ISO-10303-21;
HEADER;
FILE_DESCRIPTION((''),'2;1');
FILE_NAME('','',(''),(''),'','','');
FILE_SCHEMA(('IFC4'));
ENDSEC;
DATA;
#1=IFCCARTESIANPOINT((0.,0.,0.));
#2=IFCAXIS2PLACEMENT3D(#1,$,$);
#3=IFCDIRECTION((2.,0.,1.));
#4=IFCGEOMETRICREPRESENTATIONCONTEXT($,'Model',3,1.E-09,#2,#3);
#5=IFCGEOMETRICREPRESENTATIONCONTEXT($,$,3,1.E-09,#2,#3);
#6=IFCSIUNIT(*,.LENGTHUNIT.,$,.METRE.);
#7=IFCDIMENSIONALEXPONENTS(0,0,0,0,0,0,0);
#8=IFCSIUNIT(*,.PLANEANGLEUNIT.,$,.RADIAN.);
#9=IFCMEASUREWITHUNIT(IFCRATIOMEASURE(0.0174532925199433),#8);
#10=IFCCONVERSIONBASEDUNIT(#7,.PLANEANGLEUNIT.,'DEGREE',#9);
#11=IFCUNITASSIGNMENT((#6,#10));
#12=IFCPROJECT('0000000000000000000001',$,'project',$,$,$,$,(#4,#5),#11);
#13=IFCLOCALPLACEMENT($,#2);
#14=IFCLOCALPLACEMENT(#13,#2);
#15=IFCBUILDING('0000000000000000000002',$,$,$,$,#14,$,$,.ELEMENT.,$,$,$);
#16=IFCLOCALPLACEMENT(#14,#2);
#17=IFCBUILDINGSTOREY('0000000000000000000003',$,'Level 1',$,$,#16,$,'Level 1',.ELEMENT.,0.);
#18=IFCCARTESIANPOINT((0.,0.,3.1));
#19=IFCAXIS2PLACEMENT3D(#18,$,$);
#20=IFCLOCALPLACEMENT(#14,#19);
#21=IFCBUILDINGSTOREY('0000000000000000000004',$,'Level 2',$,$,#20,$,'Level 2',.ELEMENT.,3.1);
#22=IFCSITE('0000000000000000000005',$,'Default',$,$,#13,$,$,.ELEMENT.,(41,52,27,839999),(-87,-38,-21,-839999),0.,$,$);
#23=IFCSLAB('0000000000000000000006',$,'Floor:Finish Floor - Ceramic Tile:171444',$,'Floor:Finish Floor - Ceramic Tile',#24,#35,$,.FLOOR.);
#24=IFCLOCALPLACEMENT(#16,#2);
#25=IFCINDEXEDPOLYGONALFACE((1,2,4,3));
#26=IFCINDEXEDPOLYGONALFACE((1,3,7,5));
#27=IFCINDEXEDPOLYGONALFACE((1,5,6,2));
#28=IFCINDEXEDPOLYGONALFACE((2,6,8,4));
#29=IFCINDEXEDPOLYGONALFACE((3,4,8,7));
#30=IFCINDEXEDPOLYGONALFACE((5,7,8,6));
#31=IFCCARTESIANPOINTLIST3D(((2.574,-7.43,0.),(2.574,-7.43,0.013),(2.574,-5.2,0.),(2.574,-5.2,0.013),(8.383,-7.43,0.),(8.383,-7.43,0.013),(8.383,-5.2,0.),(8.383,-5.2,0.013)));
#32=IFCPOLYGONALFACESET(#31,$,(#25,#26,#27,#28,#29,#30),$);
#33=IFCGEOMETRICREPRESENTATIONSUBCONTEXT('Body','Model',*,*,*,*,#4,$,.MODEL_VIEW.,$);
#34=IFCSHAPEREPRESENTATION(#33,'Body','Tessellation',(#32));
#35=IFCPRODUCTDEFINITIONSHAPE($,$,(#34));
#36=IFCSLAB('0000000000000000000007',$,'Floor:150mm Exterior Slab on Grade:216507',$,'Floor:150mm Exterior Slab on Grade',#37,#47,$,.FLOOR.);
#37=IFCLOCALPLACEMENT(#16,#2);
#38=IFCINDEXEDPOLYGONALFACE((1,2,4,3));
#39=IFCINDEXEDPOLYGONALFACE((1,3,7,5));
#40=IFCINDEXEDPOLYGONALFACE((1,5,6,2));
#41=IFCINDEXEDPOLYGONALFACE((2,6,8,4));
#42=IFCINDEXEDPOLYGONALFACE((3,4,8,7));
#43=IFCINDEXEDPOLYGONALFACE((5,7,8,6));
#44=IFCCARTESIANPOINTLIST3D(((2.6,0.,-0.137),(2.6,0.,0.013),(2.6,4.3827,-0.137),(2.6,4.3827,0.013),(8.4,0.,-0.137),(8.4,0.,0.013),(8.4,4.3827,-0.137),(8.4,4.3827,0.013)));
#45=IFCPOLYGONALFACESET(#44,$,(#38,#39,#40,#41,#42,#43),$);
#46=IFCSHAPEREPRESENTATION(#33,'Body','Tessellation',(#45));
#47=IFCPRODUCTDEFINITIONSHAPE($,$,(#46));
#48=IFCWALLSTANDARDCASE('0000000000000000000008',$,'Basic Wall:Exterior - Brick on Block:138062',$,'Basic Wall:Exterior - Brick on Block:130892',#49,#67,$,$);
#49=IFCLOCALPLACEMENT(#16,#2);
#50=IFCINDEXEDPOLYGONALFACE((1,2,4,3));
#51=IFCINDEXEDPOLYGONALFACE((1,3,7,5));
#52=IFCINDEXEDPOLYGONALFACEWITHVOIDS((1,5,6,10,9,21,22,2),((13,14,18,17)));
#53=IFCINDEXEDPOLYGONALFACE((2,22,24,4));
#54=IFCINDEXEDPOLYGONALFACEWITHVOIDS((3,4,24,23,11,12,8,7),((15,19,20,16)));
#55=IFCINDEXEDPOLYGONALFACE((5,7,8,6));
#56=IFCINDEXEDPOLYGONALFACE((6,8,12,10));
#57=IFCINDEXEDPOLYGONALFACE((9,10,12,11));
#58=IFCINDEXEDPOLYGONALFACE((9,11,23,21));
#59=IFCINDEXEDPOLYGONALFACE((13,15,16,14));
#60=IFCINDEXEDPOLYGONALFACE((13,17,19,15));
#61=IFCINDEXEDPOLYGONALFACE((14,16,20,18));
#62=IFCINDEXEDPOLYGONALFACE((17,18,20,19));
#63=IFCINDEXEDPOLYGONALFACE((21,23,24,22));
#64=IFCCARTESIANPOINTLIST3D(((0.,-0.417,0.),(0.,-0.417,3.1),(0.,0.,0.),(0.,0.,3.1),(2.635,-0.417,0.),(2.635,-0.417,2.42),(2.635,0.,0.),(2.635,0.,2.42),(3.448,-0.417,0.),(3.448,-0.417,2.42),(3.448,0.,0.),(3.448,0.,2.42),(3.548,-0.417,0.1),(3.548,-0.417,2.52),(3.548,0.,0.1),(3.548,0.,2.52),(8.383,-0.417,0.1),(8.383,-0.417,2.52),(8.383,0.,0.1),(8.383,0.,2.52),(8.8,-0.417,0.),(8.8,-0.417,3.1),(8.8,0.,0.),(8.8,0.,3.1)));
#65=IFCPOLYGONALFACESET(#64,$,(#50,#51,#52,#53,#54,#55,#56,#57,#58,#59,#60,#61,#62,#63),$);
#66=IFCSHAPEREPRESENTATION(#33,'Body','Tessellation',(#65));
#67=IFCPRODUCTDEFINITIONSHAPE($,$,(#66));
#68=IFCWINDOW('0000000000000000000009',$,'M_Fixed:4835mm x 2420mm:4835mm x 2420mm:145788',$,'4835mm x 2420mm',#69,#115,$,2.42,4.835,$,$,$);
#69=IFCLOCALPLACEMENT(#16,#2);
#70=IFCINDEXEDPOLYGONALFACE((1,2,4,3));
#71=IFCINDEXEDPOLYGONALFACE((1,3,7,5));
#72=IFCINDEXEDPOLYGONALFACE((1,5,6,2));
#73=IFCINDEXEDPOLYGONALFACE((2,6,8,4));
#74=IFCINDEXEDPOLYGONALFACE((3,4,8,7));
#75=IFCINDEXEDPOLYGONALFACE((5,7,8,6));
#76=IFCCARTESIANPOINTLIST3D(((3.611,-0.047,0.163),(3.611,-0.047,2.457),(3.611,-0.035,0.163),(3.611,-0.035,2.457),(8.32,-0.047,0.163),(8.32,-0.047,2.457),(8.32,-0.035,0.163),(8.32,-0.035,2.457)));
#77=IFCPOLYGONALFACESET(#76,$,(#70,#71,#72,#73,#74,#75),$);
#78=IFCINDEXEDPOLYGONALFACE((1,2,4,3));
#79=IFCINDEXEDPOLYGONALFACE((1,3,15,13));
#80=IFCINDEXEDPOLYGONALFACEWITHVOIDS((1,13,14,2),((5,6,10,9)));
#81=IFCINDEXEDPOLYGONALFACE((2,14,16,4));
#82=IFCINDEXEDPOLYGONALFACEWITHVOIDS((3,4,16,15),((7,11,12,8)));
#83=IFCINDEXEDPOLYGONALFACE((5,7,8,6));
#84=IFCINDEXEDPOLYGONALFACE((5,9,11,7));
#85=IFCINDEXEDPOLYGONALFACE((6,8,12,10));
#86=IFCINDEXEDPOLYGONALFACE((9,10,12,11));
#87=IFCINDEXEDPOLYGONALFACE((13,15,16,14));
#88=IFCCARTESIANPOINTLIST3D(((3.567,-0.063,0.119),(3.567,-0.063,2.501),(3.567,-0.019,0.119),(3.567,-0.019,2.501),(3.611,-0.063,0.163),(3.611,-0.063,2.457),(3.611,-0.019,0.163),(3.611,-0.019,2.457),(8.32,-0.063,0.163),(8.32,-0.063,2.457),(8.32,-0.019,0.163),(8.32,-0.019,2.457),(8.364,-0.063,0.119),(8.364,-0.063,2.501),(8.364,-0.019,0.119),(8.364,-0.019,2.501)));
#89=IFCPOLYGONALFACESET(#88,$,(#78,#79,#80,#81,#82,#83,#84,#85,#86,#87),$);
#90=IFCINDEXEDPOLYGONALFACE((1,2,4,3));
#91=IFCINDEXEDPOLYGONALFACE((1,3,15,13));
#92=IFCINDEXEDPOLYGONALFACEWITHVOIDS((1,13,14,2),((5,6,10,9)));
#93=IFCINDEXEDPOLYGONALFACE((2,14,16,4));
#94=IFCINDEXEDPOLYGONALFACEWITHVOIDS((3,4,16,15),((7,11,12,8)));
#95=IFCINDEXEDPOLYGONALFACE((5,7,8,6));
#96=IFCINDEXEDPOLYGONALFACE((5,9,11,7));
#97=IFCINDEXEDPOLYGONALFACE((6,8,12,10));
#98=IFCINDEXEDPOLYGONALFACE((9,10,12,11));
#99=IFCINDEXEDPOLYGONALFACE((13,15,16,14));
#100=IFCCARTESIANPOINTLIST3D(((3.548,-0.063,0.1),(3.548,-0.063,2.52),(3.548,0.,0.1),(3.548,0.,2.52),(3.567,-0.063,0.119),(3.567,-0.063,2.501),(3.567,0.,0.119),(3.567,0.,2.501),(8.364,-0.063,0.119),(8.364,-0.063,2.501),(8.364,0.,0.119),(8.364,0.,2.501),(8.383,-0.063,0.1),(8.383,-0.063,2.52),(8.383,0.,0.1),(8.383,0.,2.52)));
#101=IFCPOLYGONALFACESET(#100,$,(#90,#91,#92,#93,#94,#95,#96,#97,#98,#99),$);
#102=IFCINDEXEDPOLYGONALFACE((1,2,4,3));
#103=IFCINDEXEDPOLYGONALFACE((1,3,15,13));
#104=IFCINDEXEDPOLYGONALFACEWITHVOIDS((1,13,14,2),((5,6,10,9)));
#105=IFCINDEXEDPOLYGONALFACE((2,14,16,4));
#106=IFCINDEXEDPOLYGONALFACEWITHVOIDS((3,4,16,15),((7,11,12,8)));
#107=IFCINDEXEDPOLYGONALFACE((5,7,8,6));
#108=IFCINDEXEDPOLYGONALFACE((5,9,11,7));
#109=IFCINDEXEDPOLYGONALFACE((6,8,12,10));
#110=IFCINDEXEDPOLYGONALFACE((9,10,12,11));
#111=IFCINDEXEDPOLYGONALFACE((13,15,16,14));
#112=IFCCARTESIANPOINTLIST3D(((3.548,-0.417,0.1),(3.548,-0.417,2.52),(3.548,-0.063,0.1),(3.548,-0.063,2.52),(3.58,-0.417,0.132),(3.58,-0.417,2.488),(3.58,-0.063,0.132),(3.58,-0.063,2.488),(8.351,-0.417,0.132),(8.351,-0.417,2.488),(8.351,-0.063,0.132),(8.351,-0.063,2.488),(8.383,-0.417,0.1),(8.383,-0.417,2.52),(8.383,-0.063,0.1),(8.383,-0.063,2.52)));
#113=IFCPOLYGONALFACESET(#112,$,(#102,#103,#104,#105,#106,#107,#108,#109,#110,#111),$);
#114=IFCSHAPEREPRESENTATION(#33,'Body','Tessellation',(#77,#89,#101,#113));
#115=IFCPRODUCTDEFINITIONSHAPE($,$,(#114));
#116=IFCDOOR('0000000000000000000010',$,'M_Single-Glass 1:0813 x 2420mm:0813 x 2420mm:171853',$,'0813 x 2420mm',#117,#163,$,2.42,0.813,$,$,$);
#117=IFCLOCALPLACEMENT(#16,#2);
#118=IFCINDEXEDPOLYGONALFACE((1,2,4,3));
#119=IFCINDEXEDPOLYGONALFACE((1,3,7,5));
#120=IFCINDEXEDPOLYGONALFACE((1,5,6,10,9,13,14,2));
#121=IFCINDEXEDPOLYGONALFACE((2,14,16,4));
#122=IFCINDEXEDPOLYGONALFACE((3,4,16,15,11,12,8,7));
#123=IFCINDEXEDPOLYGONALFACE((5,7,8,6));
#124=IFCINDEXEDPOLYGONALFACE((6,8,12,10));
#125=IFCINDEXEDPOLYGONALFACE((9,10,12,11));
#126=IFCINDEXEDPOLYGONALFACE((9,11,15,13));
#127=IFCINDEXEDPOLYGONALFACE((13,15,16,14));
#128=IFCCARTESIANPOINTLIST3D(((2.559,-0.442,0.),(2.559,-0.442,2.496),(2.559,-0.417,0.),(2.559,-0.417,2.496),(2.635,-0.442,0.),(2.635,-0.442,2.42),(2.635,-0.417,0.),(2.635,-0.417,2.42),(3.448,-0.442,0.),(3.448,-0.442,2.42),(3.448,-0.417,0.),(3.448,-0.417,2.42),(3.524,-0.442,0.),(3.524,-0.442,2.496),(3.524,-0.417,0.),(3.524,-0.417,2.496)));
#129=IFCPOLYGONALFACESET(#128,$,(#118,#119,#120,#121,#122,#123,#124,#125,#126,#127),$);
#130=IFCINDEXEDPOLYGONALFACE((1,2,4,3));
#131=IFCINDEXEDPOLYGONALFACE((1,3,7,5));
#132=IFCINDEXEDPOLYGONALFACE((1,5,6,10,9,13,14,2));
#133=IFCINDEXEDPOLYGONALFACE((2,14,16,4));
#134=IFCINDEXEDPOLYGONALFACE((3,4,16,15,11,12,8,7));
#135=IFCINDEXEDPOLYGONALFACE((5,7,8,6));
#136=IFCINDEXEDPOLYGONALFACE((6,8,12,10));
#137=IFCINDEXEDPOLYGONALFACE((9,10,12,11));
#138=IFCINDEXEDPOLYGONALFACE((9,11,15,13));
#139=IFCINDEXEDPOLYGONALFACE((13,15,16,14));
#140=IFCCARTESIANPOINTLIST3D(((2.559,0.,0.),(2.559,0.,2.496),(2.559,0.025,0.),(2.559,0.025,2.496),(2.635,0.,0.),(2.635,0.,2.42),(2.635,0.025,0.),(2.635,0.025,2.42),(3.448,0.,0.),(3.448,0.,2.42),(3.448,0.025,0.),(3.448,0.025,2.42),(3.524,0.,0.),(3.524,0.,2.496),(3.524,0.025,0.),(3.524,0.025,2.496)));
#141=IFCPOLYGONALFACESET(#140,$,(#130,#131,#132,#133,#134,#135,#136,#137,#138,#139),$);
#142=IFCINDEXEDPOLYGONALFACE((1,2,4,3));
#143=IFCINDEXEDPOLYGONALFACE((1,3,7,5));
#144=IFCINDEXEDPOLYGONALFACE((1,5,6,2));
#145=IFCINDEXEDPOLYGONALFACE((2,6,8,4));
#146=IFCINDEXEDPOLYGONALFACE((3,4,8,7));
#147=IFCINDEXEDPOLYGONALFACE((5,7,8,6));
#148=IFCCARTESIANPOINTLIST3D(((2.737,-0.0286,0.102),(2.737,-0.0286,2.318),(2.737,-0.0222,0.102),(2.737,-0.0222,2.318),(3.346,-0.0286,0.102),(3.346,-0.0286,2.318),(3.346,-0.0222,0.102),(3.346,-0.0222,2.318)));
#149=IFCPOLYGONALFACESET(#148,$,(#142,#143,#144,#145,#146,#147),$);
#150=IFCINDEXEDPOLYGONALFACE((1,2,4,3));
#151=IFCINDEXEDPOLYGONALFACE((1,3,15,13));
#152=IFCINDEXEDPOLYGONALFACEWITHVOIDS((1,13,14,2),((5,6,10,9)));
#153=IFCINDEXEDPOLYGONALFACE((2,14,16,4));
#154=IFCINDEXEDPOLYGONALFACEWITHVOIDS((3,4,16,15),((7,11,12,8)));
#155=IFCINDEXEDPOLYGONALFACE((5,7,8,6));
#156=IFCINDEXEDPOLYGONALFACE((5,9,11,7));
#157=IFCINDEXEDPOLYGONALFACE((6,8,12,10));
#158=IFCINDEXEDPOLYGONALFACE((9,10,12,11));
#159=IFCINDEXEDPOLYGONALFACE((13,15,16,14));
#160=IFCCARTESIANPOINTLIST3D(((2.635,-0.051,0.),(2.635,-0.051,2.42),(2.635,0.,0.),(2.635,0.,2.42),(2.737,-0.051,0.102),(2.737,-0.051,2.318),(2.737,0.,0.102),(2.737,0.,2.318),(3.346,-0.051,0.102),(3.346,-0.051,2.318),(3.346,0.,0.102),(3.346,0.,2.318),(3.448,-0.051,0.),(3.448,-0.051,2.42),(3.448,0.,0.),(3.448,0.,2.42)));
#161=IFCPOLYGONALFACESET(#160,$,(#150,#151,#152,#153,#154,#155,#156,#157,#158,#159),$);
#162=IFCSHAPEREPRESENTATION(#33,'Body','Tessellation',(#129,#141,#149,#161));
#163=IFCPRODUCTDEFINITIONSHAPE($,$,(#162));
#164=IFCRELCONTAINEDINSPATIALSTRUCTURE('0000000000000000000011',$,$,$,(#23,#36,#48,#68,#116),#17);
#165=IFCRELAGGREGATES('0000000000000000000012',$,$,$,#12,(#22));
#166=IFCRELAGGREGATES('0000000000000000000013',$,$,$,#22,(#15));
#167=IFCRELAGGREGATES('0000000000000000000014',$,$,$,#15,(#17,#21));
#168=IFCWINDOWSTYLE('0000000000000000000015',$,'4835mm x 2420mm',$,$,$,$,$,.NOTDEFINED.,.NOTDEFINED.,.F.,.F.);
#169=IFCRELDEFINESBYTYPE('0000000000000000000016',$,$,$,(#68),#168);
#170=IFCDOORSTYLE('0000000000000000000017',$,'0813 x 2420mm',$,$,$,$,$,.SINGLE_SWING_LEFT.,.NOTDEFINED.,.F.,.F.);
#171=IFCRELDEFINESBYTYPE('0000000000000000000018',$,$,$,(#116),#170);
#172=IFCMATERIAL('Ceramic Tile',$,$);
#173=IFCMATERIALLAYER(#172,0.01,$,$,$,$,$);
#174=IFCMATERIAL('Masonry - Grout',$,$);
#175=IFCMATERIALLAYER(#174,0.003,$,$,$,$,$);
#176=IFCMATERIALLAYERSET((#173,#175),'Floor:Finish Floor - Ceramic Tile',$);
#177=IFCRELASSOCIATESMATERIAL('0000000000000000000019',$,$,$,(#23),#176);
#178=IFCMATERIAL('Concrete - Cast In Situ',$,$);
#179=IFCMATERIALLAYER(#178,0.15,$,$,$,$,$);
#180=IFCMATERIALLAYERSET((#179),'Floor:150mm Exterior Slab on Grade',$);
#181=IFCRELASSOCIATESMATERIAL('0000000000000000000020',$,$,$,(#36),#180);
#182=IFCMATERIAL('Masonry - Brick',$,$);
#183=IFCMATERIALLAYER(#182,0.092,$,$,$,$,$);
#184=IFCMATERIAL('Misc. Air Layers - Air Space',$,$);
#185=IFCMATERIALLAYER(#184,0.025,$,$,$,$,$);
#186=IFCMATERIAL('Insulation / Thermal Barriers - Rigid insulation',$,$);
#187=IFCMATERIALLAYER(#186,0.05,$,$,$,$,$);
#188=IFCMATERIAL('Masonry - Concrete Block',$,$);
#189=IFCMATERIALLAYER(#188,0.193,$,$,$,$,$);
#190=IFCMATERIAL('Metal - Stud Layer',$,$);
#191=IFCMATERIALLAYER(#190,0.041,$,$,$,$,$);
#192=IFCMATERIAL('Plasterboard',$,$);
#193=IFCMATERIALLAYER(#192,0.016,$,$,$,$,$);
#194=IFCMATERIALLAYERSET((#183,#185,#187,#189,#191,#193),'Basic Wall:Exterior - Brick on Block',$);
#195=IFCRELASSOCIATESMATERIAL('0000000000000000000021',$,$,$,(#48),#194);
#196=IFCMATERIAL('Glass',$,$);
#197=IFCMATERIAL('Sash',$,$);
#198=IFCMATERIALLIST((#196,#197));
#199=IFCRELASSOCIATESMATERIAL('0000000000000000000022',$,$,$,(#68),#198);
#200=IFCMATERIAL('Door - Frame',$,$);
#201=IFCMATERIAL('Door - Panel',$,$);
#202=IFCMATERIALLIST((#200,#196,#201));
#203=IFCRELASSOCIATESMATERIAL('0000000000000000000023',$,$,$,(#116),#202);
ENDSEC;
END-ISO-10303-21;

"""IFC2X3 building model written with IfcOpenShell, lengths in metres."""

from ifc_helpers import new_model, entity, si_unit, converted_unit, direction, frame, frame_2d, origin, origin_2d_with_axis, place, context, subcontext, project, spatial, polyline, rectangle, outline, extrude, source, transform, mapped, material, material_list, layer, layer_set, layer_usage, type_object, type_shapes, element, fill, save


model = new_model("IFC2X3")

# Units and contexts
model_context = context("Model", 3, precision=1e-09, world=origin(), true_north=direction((2.0, 0.0, 1.0)))
context_of_model = context(None, 3, precision=1e-09, world=origin(), true_north=direction((2.0, 0.0, 1.0)))
body_context = subcontext(model_context, "Body", "Model", "MODEL_VIEW")
ifc_project = project(units=[si_unit("LENGTHUNIT", "METRE"), converted_unit("PLANEANGLEUNIT", "DEGREE", entity("IfcRatioMeasure", 0.0174532925199433), si_unit("PLANEANGLEUNIT", "RADIAN"), dimensions=[0, 0, 0, 0, 0, 0, 0])], contexts=[model_context, context_of_model])

# Site, building, storey
site_placement = place(None, origin())
site = spatial("IfcSite", under=ifc_project, at=site_placement, Name="Default", CompositionType="ELEMENT", RefLatitude=(41, 52, 27, 839999), RefLongitude=(-87, -38, -21, -839999), RefElevation=0.0)
building_placement = place(site_placement, origin())
building = spatial("IfcBuilding", under=site, at=building_placement, CompositionType="ELEMENT")
storey_1_placement = place(building_placement, origin())
storey_1 = spatial("IfcBuildingStorey", under=building, at=storey_1_placement, Name="Level 1", LongName="Level 1", CompositionType="ELEMENT", Elevation=0.0)

# Slabs
ifc_material_1 = material(Name="Ceramic Tile")
ifc_layer_1 = layer(ifc_material_1, 0.01)
ifc_material_2 = material(Name="Masonry - Grout")
ifc_layer_2 = layer(ifc_material_2, 0.003)
ifc_layer_set_1 = layer_set([ifc_layer_1, ifc_layer_2], Name="Floor:Finish Floor - Ceramic Tile")
ifc_layer_usage_1 = layer_usage(ifc_layer_set_1, "AXIS3", "POSITIVE", 0.0)
slab_1_placement = place(storey_1_placement, frame((2.574, -7.43, 0.0)))
element("IfcSlab", 1, at=slab_1_placement, inside=storey_1, material=ifc_layer_usage_1, Name="Floor:Finish Floor - Ceramic Tile:171444", ObjectType="Floor:Finish Floor - Ceramic Tile", PredefinedType="FLOOR", context=body_context, shape_type="SweptSolid", body=[
    extrude(rectangle(XDim=5.809, YDim=2.23, at=frame_2d((0.0, 0.0), x_axis=(-1.0, 0.0))), frame((2.9045, 1.115, 0.013), z_axis=(0.0, 0.0, -1.0), x_axis=(-1.0, 0.0, 0.0)), (0.0, 0.0, 1.0), 0.013),
])
ifc_material_3 = material(Name="Concrete - Cast In Situ")
ifc_layer_3 = layer(ifc_material_3, 0.15)
ifc_layer_set_2 = layer_set([ifc_layer_3], Name="Floor:150mm Exterior Slab on Grade")
ifc_layer_usage_2 = layer_usage(ifc_layer_set_2, "AXIS3", "POSITIVE", 0.0)
slab_2_placement = place(storey_1_placement, frame((2.6, 0.0, -0.137)))
element("IfcSlab", 2, at=slab_2_placement, inside=storey_1, material=ifc_layer_usage_2, Name="Floor:150mm Exterior Slab on Grade:216507", ObjectType="Floor:150mm Exterior Slab on Grade", PredefinedType="FLOOR", context=body_context, shape_type="SweptSolid", body=[
    extrude(rectangle(XDim=5.8, YDim=4.3827, at=frame_2d((0.0, 0.0), x_axis=(-1.0, 0.0))), frame((2.9, 2.1914, 0.15), z_axis=(0.0, 0.0, -1.0), x_axis=(-1.0, 0.0, 0.0)), (0.0, 0.0, 1.0), 0.15),
])

# Wall, openings, window, door
ifc_material_4 = material(Name="Masonry - Brick")
ifc_layer_4 = layer(ifc_material_4, 0.092)
ifc_material_5 = material(Name="Misc. Air Layers - Air Space")
ifc_layer_5 = layer(ifc_material_5, 0.025)
ifc_material_6 = material(Name="Insulation / Thermal Barriers - Rigid insulation")
ifc_layer_6 = layer(ifc_material_6, 0.05)
ifc_material_7 = material(Name="Masonry - Concrete Block")
ifc_layer_7 = layer(ifc_material_7, 0.193)
ifc_material_8 = material(Name="Metal - Stud Layer")
ifc_layer_8 = layer(ifc_material_8, 0.041)
ifc_material_9 = material(Name="Plasterboard")
ifc_layer_9 = layer(ifc_material_9, 0.016)
ifc_layer_set_3 = layer_set([ifc_layer_4, ifc_layer_5, ifc_layer_6, ifc_layer_7, ifc_layer_8, ifc_layer_9], Name="Basic Wall:Exterior - Brick on Block")
ifc_layer_usage_3 = layer_usage(ifc_layer_set_3, "AXIS2", "NEGATIVE", 0.2085)
wall_1_placement = place(storey_1_placement, frame((0.0, -0.2085, 0.0)))
wall_1 = element("IfcWallStandardCase", 3, at=wall_1_placement, inside=storey_1, material=ifc_layer_usage_3, Name="Basic Wall:Exterior - Brick on Block:138062", ObjectType="Basic Wall:Exterior - Brick on Block:130892", context=body_context, shape_type="SweptSolid", body=[
    extrude(rectangle(XDim=8.8, YDim=0.417, at=frame_2d((4.4, 0.0), x_axis=(-1.0, 0.0))), origin(), (0.0, 0.0, 1.0), 3.1),
])
opening_1_placement = place(wall_1_placement, frame((3.548, -0.2085, 0.1)))
opening_1 = element("IfcOpeningElement", 4, at=opening_1_placement, cuts=wall_1, ObjectType="Opening", context=body_context, shape_type="SweptSolid", body=[
    extrude(rectangle(XDim=2.42, YDim=4.835, at=frame_2d((1.21, 2.4175), x_axis=(1.0, 0.0))), frame((0.0, 0.0, 0.0), z_axis=(0.0, 1.0, 0.0), x_axis=(0.0, 0.0, 1.0)), (0.0, 0.0, 1.0), 0.417),
])
opening_2_placement = place(wall_1_placement, frame((2.635, -0.2085, 0.0)))
opening_2 = element("IfcOpeningElement", 5, at=opening_2_placement, cuts=wall_1, ObjectType="Opening", context=body_context, shape_type="SweptSolid", body=[
    extrude(rectangle(XDim=0.813, YDim=2.42, at=frame_2d((1.21, 0.4065), x_axis=(0.0, -1.0))), frame((0.0, 0.0, 0.0), z_axis=(0.0, 1.0, 0.0), x_axis=(0.0, 0.0, 1.0)), (0.0, 0.0, 1.0), 0.417),
])
ifc_material_10 = material(Name="Glass")
ifc_material_11 = material(Name="Sash")
ifc_material_list_1 = material_list([ifc_material_10, ifc_material_11])
window_style = type_object("IfcWindowStyle", Name="4835mm x 2420mm", ConstructionType="NOTDEFINED", OperationType="NOTDEFINED", ParameterTakesPrecedence=False, Sizeable=False)
shared_shape_1 = source(origin(), body_context, "Body", "SweptSolid", [
    extrude(rectangle(XDim=0.012, YDim=4.709, at=origin_2d_with_axis()), frame((2.4175, 0.376, 0.063), z_axis=(0.0, 0.0, 1.0), x_axis=(0.0, -1.0, 0.0)), (0.0, 0.0, 1.0), 2.294),
    extrude(outline(polyline([(-2.3985, -1.191), (2.3985, -1.191), (2.3985, 1.191), (-2.3985, 1.191), (-2.3985, -1.191)]), holes=[polyline([(-2.3545, -1.147), (-2.3545, 1.147), (2.3545, 1.147), (2.3545, -1.147), (-2.3545, -1.147)])]), frame((2.4175, 0.354, 1.21), z_axis=(0.0, 1.0, 0.0), x_axis=(1.0, 0.0, 0.0)), (0.0, 0.0, 1.0), 0.044),
    extrude(outline(polyline([(-2.4175, -1.21), (2.4175, -1.21), (2.4175, 1.21), (-2.4175, 1.21), (-2.4175, -1.21)]), holes=[polyline([(-2.3985, -1.191), (-2.3985, 1.191), (2.3985, 1.191), (2.3985, -1.191), (-2.3985, -1.191)])]), frame((2.4175, 0.354, 1.21), z_axis=(0.0, 1.0, 0.0), x_axis=(1.0, 0.0, 0.0)), (0.0, 0.0, 1.0), 0.063),
    extrude(outline(polyline([(-2.4175, -1.21), (2.4175, -1.21), (2.4175, 1.21), (-2.4175, 1.21), (-2.4175, -1.21)]), holes=[polyline([(-2.3855, -1.178), (-2.3855, 1.178), (2.3855, 1.178), (2.3855, -1.178), (-2.3855, -1.178)])]), frame((2.4175, 0.0, 1.21), z_axis=(0.0, 1.0, 0.0), x_axis=(1.0, 0.0, 0.0)), (0.0, 0.0, 1.0), 0.354),
])
type_shapes(window_style, [shared_shape_1])
window_placement = place(opening_1_placement, origin())
window = element("IfcWindow", 6, at=window_placement, inside=storey_1, type_object=window_style, material=ifc_material_list_1, Name="M_Fixed:4835mm x 2420mm:4835mm x 2420mm:145788", ObjectType="4835mm x 2420mm", OverallHeight=2.42, OverallWidth=4.835, context=body_context, shape_type="MappedRepresentation", body=[
    mapped(shared_shape_1, transform((0.0, 0.0, 0.0), scale=1.0)),
])
fill(opening_1, window)
ifc_material_12 = material(Name="Door - Frame")
ifc_material_13 = material(Name="Door - Panel")
ifc_material_list_2 = material_list([ifc_material_12, ifc_material_10, ifc_material_13])
door_style_1 = type_object("IfcDoorStyle", Name="0813 x 2420mm", ConstructionType="NOTDEFINED", OperationType="SINGLE_SWING_LEFT", ParameterTakesPrecedence=False, Sizeable=False)
shared_shape_2 = source(origin(), body_context, "Body", "SweptSolid", [
    extrude(outline(polyline([(-0.4065, -1.191), (-0.4065, 1.229), (-0.4825, 1.229), (-0.4825, -1.267), (0.4825, -1.267), (0.4825, 1.229), (0.4065, 1.229), (0.4065, -1.191), (-0.4065, -1.191)])), frame((0.4065, 0.0, 1.229), z_axis=(0.0, 1.0, 0.0), x_axis=(1.0, 0.0, 0.0)), (0.0, 0.0, -1.0), 0.025),
    extrude(outline(polyline([(-0.4065, -1.191), (-0.4065, 1.229), (-0.4825, 1.229), (-0.4825, -1.267), (0.4825, -1.267), (0.4825, 1.229), (0.4065, 1.229), (0.4065, -1.191), (-0.4065, -1.191)])), frame((0.4065, 0.442, 1.229), z_axis=(0.0, 1.0, 0.0), x_axis=(1.0, 0.0, 0.0)), (0.0, 0.0, -1.0), 0.025),
    extrude(rectangle(XDim=0.609, YDim=0.0064, at=frame_2d((0.0, 0.0), x_axis=(1.0, 0.0))), frame((0.4065, 0.3916, 0.102)), (0.0, 0.0, 1.0), 2.216),
    extrude(outline(polyline([(-1.21, -0.4065), (1.21, -0.4065), (1.21, 0.4065), (-1.21, 0.4065), (-1.21, -0.4065)]), holes=[polyline([(-1.108, 0.3045), (1.108, 0.3045), (1.108, -0.3045), (-1.108, -0.3045), (-1.108, 0.3045)])]), frame((0.4065, 0.417, 1.21), z_axis=(0.0, -1.0, 0.0), x_axis=(0.0, 0.0, -1.0)), (0.0, 0.0, 1.0), 0.051),
])
type_shapes(door_style_1, [shared_shape_2])
door_1_placement = place(opening_2_placement, origin())
door_1 = element("IfcDoor", 7, at=door_1_placement, inside=storey_1, type_object=door_style_1, material=ifc_material_list_2, Name="M_Single-Glass 1:0813 x 2420mm:0813 x 2420mm:171853", ObjectType="0813 x 2420mm", OverallHeight=2.42, OverallWidth=0.813, context=body_context, shape_type="MappedRepresentation", body=[
    mapped(shared_shape_2, transform((0.0, 0.0, 0.0), scale=1.0)),
])
fill(opening_2, door_1)

# Shared definitions
storey_2_placement = place(building_placement, frame((0.0, 0.0, 3.1)))
storey_2 = spatial("IfcBuildingStorey", under=building, at=storey_2_placement, Name="Level 2", LongName="Level 2", CompositionType="ELEMENT", Elevation=3.1)

save(model, "model.ifc")
